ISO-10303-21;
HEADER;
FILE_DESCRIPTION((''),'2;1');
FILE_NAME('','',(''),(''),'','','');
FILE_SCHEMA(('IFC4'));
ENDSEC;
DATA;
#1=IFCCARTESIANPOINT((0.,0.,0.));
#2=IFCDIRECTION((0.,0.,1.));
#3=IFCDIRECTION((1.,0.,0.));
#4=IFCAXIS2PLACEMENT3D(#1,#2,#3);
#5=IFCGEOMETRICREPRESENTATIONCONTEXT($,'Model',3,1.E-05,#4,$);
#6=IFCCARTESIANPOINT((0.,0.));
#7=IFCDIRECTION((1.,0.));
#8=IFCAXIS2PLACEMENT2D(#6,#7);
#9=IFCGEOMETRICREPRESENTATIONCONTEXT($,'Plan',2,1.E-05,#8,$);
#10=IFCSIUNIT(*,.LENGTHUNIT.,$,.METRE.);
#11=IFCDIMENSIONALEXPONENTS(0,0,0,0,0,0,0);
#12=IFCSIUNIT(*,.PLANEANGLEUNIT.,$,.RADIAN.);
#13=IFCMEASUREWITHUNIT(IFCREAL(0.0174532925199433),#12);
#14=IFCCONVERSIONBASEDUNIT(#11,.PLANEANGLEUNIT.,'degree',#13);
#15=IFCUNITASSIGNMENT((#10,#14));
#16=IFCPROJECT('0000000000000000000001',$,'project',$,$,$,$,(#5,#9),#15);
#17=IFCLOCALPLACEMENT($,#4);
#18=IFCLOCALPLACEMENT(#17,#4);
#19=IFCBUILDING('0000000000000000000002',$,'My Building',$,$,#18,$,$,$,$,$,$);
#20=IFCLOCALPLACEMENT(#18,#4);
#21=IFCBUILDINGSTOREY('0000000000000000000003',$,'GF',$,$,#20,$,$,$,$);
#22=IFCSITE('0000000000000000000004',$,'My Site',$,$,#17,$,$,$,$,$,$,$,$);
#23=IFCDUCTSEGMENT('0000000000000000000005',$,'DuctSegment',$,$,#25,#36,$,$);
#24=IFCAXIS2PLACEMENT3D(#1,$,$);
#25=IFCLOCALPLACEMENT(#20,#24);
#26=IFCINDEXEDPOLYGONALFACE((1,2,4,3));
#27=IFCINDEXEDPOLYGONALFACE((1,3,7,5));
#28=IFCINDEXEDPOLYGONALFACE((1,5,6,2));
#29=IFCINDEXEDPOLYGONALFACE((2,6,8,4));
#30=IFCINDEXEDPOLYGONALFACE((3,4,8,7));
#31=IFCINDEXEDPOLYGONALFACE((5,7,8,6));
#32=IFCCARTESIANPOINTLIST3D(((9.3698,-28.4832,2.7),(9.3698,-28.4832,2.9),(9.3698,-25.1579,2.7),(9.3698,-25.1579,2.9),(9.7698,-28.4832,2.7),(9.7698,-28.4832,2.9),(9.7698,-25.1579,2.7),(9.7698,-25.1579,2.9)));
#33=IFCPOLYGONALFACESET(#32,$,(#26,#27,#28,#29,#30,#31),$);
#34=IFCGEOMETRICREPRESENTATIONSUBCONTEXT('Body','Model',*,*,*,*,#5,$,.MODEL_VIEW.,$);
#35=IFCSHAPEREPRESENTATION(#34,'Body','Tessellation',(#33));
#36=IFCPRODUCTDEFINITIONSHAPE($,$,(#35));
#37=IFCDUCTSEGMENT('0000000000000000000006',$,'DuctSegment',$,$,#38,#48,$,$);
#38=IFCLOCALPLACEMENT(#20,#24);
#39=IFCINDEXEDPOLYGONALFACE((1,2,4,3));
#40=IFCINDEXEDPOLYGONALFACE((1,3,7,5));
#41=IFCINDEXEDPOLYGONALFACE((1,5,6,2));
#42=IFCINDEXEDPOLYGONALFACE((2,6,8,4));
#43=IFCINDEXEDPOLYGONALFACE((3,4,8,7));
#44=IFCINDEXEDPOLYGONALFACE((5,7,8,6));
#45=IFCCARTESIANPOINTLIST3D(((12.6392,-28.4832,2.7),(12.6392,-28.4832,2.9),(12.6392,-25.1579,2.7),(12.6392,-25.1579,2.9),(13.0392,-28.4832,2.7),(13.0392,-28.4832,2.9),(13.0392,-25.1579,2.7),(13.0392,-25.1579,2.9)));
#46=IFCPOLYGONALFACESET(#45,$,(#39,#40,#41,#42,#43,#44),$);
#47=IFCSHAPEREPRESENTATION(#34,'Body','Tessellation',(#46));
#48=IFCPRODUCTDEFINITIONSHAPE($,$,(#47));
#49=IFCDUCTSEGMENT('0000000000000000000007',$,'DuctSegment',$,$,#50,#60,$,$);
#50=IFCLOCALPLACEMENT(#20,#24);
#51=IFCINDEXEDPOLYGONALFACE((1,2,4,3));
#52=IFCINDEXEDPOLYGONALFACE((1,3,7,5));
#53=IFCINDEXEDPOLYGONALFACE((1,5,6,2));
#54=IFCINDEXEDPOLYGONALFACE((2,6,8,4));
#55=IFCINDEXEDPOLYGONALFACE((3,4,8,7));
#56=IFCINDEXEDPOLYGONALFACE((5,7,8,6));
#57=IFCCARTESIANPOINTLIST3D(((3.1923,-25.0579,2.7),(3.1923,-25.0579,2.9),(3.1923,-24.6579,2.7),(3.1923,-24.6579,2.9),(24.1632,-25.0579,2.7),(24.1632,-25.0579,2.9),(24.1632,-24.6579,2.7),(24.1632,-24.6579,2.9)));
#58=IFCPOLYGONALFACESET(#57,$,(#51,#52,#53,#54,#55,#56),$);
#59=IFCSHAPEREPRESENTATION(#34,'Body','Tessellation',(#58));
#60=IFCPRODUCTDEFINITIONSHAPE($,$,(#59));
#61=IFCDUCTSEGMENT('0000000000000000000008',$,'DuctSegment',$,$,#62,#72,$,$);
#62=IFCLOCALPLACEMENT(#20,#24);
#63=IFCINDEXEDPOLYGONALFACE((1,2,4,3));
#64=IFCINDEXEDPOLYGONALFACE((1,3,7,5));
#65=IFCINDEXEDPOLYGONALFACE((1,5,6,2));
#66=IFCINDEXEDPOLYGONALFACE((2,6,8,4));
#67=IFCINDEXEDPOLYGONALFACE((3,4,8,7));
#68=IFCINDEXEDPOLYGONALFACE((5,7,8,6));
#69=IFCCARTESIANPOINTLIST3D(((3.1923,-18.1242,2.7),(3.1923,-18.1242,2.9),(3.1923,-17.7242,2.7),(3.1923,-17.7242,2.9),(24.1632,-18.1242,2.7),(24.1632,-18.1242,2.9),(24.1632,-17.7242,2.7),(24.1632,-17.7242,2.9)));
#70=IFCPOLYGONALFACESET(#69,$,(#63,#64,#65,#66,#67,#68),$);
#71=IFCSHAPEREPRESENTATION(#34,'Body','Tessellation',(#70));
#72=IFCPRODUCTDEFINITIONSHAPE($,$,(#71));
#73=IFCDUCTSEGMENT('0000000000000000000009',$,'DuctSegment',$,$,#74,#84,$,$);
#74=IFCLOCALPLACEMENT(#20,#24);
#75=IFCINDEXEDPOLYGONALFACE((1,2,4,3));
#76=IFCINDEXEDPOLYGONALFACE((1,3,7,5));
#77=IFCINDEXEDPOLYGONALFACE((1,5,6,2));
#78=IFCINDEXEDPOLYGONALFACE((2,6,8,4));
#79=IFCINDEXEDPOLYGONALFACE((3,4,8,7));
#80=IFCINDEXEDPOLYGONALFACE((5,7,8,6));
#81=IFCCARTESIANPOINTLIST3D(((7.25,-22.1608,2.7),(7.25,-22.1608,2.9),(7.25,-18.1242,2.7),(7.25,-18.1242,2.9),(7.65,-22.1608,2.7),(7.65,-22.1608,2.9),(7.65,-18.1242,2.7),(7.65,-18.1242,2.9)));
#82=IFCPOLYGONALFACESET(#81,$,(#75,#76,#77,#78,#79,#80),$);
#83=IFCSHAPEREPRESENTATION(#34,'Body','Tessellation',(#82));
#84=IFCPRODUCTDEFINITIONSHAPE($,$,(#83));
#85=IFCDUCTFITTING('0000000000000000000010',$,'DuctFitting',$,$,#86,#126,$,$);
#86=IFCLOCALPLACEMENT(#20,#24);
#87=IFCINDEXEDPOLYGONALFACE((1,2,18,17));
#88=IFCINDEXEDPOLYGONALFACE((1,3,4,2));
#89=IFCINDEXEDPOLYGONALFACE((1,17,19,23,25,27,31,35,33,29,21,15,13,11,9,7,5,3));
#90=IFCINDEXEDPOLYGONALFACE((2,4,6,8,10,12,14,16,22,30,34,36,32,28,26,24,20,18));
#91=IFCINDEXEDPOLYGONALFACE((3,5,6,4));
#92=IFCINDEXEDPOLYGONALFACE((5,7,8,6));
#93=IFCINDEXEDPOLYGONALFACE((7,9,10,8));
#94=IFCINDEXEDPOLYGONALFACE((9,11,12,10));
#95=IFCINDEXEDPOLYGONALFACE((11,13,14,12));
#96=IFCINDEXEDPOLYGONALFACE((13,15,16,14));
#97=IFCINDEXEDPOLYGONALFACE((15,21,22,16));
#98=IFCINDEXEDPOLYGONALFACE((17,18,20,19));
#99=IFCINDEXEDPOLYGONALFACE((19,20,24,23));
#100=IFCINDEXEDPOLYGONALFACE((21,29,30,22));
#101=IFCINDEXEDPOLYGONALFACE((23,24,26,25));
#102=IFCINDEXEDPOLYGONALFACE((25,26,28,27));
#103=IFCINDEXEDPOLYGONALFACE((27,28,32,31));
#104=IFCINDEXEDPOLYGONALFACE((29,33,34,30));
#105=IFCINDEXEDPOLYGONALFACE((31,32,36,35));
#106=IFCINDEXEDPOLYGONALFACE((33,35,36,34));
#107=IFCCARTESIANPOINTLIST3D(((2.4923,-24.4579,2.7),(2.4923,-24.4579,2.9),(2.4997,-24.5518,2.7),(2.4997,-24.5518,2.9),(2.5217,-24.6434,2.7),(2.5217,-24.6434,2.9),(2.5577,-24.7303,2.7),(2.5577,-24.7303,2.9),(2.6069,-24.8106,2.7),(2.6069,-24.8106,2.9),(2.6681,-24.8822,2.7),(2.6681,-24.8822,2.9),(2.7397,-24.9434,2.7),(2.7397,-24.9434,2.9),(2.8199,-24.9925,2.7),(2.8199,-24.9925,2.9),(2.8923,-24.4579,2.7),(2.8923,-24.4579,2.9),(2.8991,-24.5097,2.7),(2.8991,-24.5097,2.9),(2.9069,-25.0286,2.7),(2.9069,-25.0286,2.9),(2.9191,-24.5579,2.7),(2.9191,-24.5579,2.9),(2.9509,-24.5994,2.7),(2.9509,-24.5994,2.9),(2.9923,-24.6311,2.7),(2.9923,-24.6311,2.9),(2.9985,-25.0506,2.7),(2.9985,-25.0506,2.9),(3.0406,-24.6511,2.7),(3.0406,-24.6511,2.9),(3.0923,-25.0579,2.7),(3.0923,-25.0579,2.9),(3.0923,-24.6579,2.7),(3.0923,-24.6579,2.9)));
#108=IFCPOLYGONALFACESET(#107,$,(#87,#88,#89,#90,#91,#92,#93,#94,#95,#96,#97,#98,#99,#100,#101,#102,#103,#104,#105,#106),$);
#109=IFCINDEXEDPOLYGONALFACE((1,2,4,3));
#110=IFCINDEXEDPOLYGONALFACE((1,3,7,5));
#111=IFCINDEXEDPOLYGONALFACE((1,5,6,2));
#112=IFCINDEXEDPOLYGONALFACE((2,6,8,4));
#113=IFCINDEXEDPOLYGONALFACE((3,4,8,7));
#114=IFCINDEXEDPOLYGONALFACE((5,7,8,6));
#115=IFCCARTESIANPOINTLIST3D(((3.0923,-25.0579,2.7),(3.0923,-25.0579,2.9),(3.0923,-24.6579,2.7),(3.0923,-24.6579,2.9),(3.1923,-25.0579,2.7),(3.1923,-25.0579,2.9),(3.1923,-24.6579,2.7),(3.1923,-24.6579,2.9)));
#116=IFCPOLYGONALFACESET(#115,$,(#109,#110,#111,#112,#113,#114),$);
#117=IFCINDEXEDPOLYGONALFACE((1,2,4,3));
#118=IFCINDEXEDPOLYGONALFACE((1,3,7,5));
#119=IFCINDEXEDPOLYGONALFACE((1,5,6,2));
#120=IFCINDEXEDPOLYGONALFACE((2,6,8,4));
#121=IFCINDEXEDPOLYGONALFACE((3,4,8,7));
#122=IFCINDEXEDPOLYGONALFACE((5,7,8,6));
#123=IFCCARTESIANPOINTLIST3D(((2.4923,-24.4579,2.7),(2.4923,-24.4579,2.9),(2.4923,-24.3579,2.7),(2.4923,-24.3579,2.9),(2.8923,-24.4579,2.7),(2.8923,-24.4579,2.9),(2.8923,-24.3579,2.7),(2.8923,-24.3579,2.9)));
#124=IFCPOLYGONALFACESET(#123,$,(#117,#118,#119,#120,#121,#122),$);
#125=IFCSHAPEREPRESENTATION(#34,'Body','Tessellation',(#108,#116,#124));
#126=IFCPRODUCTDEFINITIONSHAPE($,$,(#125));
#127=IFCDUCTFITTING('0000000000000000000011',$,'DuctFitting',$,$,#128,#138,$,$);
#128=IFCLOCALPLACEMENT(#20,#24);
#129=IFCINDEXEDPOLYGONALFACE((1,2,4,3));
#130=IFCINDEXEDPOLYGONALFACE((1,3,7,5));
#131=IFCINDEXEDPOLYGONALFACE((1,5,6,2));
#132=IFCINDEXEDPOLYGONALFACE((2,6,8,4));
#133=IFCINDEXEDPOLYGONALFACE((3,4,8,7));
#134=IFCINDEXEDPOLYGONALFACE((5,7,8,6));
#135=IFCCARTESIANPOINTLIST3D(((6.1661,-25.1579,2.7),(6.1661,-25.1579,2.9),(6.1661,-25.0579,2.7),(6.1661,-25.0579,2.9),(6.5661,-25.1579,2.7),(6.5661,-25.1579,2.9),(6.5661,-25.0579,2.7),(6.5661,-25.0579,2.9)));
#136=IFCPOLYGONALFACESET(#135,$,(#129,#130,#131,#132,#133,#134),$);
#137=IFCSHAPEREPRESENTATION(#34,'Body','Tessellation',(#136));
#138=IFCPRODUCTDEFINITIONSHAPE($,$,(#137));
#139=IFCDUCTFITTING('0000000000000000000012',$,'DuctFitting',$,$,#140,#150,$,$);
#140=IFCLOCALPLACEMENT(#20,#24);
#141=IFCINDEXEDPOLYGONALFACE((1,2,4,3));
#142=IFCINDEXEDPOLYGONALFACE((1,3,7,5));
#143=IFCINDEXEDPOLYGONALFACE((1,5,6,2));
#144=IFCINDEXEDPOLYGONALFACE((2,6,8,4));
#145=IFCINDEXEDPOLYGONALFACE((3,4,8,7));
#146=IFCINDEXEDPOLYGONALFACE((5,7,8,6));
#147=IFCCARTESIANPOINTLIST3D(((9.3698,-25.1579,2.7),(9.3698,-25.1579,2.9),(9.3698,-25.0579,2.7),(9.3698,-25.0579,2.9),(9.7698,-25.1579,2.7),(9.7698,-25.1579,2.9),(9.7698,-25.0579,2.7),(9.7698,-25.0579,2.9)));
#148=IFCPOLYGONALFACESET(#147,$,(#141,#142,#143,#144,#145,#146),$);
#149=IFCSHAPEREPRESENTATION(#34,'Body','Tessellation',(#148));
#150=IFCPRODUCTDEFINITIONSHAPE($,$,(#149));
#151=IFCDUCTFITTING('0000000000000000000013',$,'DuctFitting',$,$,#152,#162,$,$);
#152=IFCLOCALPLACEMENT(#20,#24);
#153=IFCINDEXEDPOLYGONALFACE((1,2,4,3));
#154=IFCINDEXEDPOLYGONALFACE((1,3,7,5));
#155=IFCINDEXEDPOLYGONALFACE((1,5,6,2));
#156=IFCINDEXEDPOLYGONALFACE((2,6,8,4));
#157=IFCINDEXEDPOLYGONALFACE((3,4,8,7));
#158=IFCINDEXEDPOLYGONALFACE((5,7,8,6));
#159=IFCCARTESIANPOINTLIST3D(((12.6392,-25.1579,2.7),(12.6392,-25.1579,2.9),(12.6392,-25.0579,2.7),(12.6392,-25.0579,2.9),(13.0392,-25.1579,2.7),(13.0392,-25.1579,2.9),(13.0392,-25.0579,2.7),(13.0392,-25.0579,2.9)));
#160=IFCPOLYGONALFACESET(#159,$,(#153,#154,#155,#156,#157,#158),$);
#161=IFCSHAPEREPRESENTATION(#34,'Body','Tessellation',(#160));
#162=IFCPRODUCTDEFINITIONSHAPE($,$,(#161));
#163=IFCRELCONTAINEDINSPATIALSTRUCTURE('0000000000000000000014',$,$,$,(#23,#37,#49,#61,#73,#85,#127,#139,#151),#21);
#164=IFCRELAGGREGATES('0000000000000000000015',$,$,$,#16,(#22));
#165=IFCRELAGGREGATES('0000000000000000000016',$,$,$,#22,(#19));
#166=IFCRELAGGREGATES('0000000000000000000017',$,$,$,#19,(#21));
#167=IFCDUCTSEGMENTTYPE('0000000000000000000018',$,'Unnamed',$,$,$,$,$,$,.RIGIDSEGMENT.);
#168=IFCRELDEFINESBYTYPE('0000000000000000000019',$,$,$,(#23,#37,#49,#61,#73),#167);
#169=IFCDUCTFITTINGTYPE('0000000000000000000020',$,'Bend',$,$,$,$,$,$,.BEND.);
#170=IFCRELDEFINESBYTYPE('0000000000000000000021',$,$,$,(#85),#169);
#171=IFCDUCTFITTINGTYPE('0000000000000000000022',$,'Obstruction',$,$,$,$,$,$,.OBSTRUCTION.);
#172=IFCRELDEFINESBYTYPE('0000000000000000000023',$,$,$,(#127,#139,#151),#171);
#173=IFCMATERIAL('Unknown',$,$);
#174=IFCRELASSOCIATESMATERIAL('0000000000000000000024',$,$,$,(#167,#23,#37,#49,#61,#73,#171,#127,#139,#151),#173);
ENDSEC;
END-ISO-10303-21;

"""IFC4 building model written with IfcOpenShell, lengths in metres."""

from ifc_helpers import new_model, entity, si_unit, converted_unit, frame, origin_with_axes, origin_2d_with_axis, place, context, subcontext, project, spatial, line, arc, indexed_curve, rectangle, outline, extrude, source, transform, mapped, material, material_profile, profile_set, profile_usage, type_object, type_shapes, element, save


model = new_model("IFC4")

# Units and contexts
model_context = context("Model", 3, precision=1e-05, world=origin_with_axes())
plan_context = context("Plan", 2, precision=1e-05, world=origin_2d_with_axis())
body_context_1 = subcontext(model_context, "Body", "Model", "MODEL_VIEW")
ifc_project = project(units=[si_unit("LENGTHUNIT", "METRE"), converted_unit("PLANEANGLEUNIT", "degree", entity("IfcReal", 0.0174532925199433), si_unit("PLANEANGLEUNIT", "RADIAN"), dimensions=[0, 0, 0, 0, 0, 0, 0])], contexts=[model_context, plan_context])

# Site, building, storey
site_placement = place(None, origin_with_axes())
site = spatial("IfcSite", under=ifc_project, at=site_placement, Name="My Site")
building_placement = place(site_placement, origin_with_axes())
building = spatial("IfcBuilding", under=site, at=building_placement, Name="My Building")
storey_placement = place(building_placement, origin_with_axes())
storey = spatial("IfcBuildingStorey", under=building, at=storey_placement, Name="GF")

# Shared definitions
ifc_material = material(Name="Unknown")

# Duct segments
ifc_material_profile_1 = material_profile(ifc_material, rectangle(XDim=0.4, YDim=0.2))
ifc_profile_set_1 = profile_set([ifc_material_profile_1])
duct_segment_type = type_object("IfcDuctSegmentType", Name="Unnamed", PredefinedType="RIGIDSEGMENT", material=ifc_profile_set_1)
ifc_profile_usage_1 = profile_usage(ifc_profile_set_1, cardinal=5)
duct_segment_1_placement = place(storey_placement, frame((9.5698, -25.1579, 2.8), z_axis=(0.0, -1.0, 0.0), x_axis=(1.0, 0.0, 0.0)))
element("IfcDuctSegment", 1, at=duct_segment_1_placement, inside=storey, type_object=duct_segment_type, material=ifc_profile_usage_1, Name="DuctSegment", context=body_context_1, shape_type="SweptSolid", body=[
    extrude(rectangle(XDim=0.4, YDim=0.2), origin_with_axes(), (0.0, 0.0, 1.0), 3.3252),
])
ifc_profile_usage_2 = profile_usage(ifc_profile_set_1, cardinal=5)
duct_segment_2_placement = place(storey_placement, frame((12.8392, -25.1579, 2.8), z_axis=(0.0, -1.0, 0.0), x_axis=(1.0, 0.0, 0.0)))
element("IfcDuctSegment", 2, at=duct_segment_2_placement, inside=storey, type_object=duct_segment_type, material=ifc_profile_usage_2, Name="DuctSegment", context=body_context_1, shape_type="SweptSolid", body=[
    extrude(rectangle(XDim=0.4, YDim=0.2), origin_with_axes(), (0.0, 0.0, 1.0), 3.3252),
])
ifc_profile_usage_3 = profile_usage(ifc_profile_set_1, cardinal=5)
duct_segment_3_placement = place(storey_placement, frame((3.1923, -24.8579, 2.8), z_axis=(1.0, 0.0, 0.0), x_axis=(0.0, 1.0, 0.0)))
element("IfcDuctSegment", 3, at=duct_segment_3_placement, inside=storey, type_object=duct_segment_type, material=ifc_profile_usage_3, Name="DuctSegment", context=body_context_1, shape_type="SweptSolid", body=[
    extrude(rectangle(XDim=0.4, YDim=0.2), origin_with_axes(), (0.0, 0.0, 1.0), 20.9709),
])
ifc_profile_usage_4 = profile_usage(ifc_profile_set_1, cardinal=5)
duct_segment_4_placement = place(storey_placement, frame((3.1923, -17.9242, 2.8), z_axis=(1.0, 0.0, 0.0), x_axis=(0.0, 1.0, 0.0)))
element("IfcDuctSegment", 4, at=duct_segment_4_placement, inside=storey, type_object=duct_segment_type, material=ifc_profile_usage_4, Name="DuctSegment", context=body_context_1, shape_type="SweptSolid", body=[
    extrude(rectangle(XDim=0.4, YDim=0.2), origin_with_axes(), (0.0, 0.0, 1.0), 20.9709),
])
ifc_profile_usage_5 = profile_usage(ifc_profile_set_1, cardinal=5)
duct_segment_5_placement = place(storey_placement, frame((7.45, -18.1242, 2.8), z_axis=(0.0, -1.0, 0.0), x_axis=(1.0, 0.0, 0.0)))
element("IfcDuctSegment", 5, at=duct_segment_5_placement, inside=storey, type_object=duct_segment_type, material=ifc_profile_usage_5, Name="DuctSegment", context=body_context_1, shape_type="SweptSolid", body=[
    extrude(rectangle(XDim=0.4, YDim=0.2), origin_with_axes(), (0.0, 0.0, 1.0), 4.0366),
])

# Duct fittings
duct_fitting_type_1 = type_object("IfcDuctFittingType", Name="Bend", PredefinedType="BEND")
shared_shape_1 = source(origin_with_axes(), body_context_1, "Body", "SweptSolid", [
    extrude(outline(indexed_curve([(0.2, 0.0), (0.2586, 0.1414), (0.4, 0.2), (0.4, 0.6), (-0.0243, 0.4243), (-0.2, 0.0)], segments=[arc(1, 2, 3), line(3, 4), arc(4, 5, 6), line(6, 1)])), frame((0.0, -0.1, 0.1), z_axis=(0.0, -1.0, 0.0), x_axis=(1.0, 0.0, 0.0)), (0.0, 0.0, -1.0), 0.2),
    extrude(rectangle(XDim=0.4, YDim=0.2), origin_with_axes(), (0.0, 0.0, 1.0), 0.1),
    extrude(rectangle(XDim=0.4, YDim=0.2), frame((0.4, 0.0, 0.5), z_axis=(1.0, 0.0, 0.0), x_axis=(0.0, 0.0, 1.0)), (0.0, 0.0, 1.0), 0.1),
])
type_shapes(duct_fitting_type_1, [shared_shape_1])
duct_fitting_1_placement = place(storey_placement, frame((3.1923, -24.8579, 2.8), z_axis=(-1.0, 0.0, 0.0), x_axis=(0.0, 1.0, 0.0)))
element("IfcDuctFitting", 6, at=duct_fitting_1_placement, inside=storey, type_object=duct_fitting_type_1, Name="DuctFitting", context=body_context_1, shape_type="MappedRepresentation", body=[
    mapped(shared_shape_1, transform((0.0, 0.0, 0.0), x_axis=(1.0, 0.0, 0.0), y_axis=(0.0, 1.0, 0.0), z_axis=(0.0, 0.0, 1.0), scale=1.0)),
])
ifc_material_profile_2 = material_profile(ifc_material, rectangle(XDim=0.4, YDim=0.2))
ifc_profile_set_2 = profile_set([ifc_material_profile_2])
ifc_profile_usage_6 = profile_usage(ifc_profile_set_2, cardinal=5)
duct_fitting_type_2 = type_object("IfcDuctFittingType", Name="Obstruction", PredefinedType="OBSTRUCTION", material=ifc_profile_set_2)
duct_fitting_2_placement = place(storey_placement, frame((6.3661, -25.0579, 2.8), z_axis=(0.0, -1.0, 0.0), x_axis=(1.0, 0.0, 0.0)))
element("IfcDuctFitting", 7, at=duct_fitting_2_placement, inside=storey, type_object=duct_fitting_type_2, material=ifc_profile_usage_6, Name="DuctFitting", context=body_context_1, shape_type="SweptSolid", body=[
    extrude(rectangle(XDim=0.4, YDim=0.2), origin_with_axes(), (0.0, 0.0, 1.0), 0.1),
])
ifc_profile_usage_7 = profile_usage(ifc_profile_set_2, cardinal=5)
duct_fitting_3_placement = place(storey_placement, frame((9.5698, -25.0579, 2.8), z_axis=(0.0, -1.0, 0.0), x_axis=(1.0, 0.0, 0.0)))
element("IfcDuctFitting", 8, at=duct_fitting_3_placement, inside=storey, type_object=duct_fitting_type_2, material=ifc_profile_usage_7, Name="DuctFitting", context=body_context_1, shape_type="SweptSolid", body=[
    extrude(rectangle(XDim=0.4, YDim=0.2), origin_with_axes(), (0.0, 0.0, 1.0), 0.1),
])
ifc_profile_usage_8 = profile_usage(ifc_profile_set_2, cardinal=5)
duct_fitting_4_placement = place(storey_placement, frame((12.8392, -25.0579, 2.8), z_axis=(0.0, -1.0, 0.0), x_axis=(1.0, 0.0, 0.0)))
element("IfcDuctFitting", 9, at=duct_fitting_4_placement, inside=storey, type_object=duct_fitting_type_2, material=ifc_profile_usage_8, Name="DuctFitting", context=body_context_1, shape_type="SweptSolid", body=[
    extrude(rectangle(XDim=0.4, YDim=0.2), origin_with_axes(), (0.0, 0.0, 1.0), 0.1),
])

save(model, "model.ifc")
